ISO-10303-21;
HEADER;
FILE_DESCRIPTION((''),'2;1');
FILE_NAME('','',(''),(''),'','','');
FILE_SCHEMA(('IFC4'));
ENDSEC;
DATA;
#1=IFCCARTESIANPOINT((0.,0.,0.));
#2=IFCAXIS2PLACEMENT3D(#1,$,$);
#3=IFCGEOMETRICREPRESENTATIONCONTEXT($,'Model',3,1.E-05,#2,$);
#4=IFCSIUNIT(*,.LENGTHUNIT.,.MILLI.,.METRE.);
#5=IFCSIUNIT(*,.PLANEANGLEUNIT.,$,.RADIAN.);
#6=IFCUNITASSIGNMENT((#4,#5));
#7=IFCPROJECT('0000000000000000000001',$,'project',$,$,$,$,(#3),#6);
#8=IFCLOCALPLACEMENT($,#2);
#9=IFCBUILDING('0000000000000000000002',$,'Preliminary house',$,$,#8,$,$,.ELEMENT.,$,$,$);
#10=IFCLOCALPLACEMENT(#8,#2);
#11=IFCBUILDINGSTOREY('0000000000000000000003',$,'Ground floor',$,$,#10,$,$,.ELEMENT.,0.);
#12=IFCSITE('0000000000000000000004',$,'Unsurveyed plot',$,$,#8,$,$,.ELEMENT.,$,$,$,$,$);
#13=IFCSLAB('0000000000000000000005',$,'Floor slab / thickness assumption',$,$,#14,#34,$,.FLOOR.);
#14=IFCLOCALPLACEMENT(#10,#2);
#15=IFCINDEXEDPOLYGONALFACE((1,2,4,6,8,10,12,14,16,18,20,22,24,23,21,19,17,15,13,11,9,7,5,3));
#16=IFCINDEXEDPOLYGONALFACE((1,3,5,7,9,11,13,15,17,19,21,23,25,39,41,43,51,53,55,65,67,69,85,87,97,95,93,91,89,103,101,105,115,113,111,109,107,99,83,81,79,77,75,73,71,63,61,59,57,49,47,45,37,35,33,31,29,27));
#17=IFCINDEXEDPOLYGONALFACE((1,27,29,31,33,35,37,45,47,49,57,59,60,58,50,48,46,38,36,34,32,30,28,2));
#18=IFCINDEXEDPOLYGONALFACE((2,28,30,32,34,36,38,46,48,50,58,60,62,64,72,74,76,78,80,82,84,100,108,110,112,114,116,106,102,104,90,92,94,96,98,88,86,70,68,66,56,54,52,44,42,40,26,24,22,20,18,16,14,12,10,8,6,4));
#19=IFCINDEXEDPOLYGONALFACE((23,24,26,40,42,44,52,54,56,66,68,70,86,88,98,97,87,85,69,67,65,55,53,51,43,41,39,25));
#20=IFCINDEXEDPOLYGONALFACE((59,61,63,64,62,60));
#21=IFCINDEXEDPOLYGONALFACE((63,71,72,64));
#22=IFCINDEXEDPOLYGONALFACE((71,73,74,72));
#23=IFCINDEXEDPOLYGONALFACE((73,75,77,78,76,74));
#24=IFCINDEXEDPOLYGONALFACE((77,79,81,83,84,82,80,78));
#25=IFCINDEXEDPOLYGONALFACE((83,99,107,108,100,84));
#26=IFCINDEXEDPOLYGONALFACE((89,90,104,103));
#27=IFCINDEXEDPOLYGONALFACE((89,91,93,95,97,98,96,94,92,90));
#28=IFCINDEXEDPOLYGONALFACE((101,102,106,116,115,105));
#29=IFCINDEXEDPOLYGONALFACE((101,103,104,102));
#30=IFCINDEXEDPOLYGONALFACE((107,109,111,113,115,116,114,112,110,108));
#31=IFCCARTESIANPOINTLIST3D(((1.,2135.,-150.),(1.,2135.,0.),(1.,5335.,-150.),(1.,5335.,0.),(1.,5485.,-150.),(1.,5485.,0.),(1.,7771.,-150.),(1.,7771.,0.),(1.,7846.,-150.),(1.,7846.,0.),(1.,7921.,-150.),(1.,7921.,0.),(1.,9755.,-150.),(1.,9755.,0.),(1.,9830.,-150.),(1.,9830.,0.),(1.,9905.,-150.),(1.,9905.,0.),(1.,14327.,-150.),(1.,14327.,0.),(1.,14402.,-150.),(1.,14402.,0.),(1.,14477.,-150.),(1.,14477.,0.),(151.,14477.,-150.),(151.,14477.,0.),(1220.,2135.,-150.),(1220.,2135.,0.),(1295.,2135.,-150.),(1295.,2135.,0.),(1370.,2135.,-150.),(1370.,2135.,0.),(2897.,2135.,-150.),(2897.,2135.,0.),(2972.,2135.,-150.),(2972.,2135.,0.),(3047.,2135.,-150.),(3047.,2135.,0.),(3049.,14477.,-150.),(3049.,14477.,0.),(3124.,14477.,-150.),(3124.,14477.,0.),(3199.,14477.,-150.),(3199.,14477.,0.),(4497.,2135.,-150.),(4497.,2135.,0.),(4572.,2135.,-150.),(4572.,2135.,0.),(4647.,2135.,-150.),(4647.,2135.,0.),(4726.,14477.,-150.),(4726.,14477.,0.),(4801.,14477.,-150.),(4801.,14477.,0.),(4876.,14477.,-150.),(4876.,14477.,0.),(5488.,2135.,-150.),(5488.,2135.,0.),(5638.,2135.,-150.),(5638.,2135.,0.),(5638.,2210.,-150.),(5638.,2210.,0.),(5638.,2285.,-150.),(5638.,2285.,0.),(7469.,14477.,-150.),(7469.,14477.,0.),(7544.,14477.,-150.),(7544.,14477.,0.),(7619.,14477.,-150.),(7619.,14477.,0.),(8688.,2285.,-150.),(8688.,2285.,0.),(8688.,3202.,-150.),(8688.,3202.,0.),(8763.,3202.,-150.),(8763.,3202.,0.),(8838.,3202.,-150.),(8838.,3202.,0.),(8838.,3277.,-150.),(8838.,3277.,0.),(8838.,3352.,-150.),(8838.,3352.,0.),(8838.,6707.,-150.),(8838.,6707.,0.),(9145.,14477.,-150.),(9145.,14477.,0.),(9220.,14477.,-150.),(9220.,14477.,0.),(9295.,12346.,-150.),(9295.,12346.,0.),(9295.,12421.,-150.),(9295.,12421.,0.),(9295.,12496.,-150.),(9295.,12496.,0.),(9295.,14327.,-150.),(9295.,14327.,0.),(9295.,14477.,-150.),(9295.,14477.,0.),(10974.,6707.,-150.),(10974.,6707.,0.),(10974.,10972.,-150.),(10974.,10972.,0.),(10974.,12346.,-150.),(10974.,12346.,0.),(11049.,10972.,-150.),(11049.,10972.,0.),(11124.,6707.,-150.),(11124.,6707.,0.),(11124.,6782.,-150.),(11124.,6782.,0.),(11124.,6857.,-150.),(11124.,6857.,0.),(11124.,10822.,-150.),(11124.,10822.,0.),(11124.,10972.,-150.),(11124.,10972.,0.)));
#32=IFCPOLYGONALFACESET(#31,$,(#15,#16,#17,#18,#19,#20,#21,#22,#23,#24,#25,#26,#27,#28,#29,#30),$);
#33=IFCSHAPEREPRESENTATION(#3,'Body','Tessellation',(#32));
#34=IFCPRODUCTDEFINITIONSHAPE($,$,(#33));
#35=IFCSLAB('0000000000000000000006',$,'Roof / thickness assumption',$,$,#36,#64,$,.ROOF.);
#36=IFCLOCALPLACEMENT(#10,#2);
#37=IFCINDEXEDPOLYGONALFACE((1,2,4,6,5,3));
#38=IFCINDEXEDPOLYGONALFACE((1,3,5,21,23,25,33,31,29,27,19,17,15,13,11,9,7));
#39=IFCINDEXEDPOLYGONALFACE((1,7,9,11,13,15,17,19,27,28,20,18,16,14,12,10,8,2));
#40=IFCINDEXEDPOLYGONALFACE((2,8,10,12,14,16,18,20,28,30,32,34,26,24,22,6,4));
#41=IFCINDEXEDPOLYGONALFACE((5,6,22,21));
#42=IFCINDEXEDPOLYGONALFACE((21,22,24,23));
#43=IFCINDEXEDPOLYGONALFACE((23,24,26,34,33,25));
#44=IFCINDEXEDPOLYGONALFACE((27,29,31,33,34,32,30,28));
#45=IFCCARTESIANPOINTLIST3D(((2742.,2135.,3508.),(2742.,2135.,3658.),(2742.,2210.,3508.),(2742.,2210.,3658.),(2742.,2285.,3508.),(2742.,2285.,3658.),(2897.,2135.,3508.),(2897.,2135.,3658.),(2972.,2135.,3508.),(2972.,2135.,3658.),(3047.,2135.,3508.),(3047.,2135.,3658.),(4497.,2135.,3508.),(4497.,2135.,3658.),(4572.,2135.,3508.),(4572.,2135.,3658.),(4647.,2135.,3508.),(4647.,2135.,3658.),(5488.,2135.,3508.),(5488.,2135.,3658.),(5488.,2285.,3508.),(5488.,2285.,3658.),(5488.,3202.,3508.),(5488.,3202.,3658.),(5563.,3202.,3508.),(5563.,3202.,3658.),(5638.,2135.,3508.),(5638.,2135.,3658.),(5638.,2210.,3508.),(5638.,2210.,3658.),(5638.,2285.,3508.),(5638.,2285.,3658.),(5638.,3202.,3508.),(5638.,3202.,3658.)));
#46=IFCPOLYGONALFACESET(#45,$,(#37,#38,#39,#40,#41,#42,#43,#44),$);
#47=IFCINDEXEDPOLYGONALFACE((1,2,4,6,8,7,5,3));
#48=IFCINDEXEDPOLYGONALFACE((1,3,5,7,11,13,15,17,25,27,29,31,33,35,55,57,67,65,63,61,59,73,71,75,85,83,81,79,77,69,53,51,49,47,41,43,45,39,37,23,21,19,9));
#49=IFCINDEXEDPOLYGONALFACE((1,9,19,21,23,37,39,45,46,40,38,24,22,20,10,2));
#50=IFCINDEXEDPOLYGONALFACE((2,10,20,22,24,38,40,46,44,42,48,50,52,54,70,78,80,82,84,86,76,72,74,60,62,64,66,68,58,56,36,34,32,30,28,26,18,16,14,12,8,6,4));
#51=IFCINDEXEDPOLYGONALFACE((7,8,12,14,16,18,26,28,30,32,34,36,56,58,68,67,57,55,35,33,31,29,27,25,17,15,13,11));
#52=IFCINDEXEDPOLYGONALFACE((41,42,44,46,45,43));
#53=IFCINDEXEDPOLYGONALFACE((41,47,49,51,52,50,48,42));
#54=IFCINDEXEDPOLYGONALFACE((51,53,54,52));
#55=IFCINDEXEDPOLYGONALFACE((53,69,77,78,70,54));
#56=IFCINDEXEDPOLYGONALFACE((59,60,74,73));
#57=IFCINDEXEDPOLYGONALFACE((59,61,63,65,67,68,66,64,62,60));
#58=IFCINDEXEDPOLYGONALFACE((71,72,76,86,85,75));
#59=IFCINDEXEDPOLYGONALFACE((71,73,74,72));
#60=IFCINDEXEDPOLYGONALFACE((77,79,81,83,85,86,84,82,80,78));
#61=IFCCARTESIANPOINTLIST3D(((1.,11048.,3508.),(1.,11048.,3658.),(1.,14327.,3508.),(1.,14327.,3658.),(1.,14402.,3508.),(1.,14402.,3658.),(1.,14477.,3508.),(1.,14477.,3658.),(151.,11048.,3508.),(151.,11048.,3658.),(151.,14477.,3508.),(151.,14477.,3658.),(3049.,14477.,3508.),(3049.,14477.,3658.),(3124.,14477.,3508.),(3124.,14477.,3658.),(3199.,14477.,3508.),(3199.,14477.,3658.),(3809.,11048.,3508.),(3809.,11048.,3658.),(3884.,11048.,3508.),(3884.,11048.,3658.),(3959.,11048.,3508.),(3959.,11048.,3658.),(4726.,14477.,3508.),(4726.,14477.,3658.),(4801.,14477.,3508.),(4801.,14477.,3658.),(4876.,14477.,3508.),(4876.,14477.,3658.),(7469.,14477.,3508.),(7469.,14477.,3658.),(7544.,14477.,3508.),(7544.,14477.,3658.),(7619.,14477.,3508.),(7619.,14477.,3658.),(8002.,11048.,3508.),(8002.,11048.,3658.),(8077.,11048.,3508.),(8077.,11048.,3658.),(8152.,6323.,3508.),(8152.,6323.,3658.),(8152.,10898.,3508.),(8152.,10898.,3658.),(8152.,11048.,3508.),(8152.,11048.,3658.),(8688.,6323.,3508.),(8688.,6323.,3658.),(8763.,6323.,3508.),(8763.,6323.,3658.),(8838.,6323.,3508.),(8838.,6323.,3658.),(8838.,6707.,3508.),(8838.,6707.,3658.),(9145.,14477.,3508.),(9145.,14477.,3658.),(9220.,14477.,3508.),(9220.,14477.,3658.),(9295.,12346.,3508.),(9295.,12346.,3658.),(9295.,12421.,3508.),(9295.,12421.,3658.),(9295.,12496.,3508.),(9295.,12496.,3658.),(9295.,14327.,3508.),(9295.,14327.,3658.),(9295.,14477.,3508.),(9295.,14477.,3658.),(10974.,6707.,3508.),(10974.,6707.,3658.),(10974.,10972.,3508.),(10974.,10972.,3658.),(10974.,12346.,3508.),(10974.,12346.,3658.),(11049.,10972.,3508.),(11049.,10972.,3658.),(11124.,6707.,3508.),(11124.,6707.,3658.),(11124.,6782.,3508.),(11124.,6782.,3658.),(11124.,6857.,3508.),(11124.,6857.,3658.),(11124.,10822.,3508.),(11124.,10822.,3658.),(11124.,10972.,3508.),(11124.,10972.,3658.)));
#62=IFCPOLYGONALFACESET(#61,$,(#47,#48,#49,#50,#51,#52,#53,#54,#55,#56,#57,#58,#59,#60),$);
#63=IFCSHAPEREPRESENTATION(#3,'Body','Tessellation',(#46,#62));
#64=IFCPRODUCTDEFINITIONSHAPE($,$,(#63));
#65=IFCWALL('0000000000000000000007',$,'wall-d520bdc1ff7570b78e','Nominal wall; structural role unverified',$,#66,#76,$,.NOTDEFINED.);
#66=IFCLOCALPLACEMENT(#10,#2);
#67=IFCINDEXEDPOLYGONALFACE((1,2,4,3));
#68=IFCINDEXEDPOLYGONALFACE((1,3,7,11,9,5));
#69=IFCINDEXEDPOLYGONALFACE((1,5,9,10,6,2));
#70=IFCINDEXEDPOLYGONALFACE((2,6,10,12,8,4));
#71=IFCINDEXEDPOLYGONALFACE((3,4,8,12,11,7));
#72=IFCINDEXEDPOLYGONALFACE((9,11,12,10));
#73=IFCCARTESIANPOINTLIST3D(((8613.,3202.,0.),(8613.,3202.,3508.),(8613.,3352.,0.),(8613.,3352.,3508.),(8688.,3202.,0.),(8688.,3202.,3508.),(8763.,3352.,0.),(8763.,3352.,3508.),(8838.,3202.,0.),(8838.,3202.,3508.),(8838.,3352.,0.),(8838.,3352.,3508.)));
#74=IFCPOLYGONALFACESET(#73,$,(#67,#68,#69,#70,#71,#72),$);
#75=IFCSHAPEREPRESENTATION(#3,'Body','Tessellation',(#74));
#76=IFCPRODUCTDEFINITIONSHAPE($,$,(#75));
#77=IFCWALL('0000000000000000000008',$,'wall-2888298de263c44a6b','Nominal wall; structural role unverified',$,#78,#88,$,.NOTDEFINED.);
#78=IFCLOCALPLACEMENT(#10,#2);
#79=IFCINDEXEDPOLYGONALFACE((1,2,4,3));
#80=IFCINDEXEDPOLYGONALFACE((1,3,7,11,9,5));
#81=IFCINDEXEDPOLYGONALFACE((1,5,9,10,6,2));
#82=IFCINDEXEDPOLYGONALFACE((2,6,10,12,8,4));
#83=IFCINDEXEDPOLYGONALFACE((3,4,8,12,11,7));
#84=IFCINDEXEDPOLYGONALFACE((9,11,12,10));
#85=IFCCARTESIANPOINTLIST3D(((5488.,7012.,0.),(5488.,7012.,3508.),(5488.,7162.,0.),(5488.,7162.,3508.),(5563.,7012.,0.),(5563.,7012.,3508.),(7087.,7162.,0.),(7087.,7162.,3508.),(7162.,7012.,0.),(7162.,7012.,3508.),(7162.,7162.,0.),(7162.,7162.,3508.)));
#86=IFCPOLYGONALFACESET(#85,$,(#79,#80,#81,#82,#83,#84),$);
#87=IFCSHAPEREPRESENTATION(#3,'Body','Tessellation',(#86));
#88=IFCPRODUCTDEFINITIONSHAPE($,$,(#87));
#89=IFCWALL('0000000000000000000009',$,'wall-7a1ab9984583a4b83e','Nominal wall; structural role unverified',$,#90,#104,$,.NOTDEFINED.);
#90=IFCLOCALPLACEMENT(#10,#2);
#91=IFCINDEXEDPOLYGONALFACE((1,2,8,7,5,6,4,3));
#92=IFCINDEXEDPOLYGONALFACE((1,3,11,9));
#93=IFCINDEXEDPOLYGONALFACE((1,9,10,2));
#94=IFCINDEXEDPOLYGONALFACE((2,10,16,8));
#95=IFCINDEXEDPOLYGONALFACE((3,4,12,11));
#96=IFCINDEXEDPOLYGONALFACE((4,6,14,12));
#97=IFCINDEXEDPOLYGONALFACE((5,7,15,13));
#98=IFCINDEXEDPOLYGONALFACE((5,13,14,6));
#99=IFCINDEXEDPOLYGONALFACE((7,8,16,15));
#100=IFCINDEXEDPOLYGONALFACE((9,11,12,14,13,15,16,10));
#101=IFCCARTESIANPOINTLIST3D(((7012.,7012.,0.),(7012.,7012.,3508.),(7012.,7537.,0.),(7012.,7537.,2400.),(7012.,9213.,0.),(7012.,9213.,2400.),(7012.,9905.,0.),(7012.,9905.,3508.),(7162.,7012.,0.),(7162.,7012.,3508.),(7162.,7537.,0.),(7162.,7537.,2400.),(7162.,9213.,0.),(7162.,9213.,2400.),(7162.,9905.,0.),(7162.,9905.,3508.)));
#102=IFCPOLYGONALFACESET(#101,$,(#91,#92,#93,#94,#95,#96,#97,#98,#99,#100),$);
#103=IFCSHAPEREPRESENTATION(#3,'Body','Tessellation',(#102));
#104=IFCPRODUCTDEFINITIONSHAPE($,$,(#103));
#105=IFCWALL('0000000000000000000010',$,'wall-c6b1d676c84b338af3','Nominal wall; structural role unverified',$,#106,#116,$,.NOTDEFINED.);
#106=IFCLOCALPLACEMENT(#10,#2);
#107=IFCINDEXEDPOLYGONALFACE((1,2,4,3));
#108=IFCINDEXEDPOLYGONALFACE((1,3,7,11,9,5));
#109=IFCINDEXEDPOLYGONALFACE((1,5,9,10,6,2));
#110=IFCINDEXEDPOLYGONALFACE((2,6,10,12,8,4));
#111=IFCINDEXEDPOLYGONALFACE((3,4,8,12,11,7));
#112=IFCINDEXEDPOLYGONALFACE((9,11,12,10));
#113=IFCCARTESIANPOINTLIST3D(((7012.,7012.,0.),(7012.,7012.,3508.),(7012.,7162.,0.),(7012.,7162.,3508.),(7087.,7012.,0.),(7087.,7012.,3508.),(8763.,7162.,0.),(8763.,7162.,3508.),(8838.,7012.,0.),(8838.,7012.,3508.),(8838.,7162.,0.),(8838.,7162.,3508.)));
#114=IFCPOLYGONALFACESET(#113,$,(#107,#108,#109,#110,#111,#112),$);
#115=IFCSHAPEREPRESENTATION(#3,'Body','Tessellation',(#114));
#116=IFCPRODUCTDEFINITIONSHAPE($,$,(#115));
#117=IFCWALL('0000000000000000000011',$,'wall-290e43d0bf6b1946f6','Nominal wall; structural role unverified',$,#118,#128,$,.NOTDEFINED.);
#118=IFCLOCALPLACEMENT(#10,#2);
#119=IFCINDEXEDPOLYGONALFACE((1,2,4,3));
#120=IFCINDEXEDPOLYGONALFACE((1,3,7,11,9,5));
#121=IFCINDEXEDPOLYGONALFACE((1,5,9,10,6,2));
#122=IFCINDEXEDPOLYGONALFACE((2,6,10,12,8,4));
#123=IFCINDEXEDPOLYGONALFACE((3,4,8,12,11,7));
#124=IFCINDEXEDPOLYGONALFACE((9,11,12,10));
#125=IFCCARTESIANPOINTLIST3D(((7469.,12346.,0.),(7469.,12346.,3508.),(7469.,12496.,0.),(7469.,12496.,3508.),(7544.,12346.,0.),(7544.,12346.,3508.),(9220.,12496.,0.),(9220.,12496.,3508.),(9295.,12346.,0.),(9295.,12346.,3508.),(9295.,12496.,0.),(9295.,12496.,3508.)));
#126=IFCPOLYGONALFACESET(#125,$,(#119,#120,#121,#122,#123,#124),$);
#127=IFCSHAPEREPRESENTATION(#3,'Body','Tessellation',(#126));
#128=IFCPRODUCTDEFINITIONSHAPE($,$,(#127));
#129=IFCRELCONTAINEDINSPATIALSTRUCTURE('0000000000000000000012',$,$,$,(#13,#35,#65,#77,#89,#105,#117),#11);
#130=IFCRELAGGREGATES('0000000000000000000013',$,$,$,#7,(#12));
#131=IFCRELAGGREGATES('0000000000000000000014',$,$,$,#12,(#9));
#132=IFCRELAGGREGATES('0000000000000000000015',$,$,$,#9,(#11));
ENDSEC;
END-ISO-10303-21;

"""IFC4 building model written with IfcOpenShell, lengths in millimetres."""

from ifc_helpers import new_model, si_unit, frame, origin, place, context, project, spatial, polyline, outline, extrude, element, save


model = new_model("IFC4")

# Units and contexts
model_context = context("Model", 3, precision=1e-05, world=origin())
ifc_project = project(units=[si_unit("LENGTHUNIT", "METRE", prefix="MILLI"), si_unit("PLANEANGLEUNIT", "RADIAN")], contexts=[model_context])

# Site, building, storey
placement_1 = place(None, origin())
site = spatial("IfcSite", under=ifc_project, at=placement_1, Name="Unsurveyed plot", CompositionType="ELEMENT")
building = spatial("IfcBuilding", under=site, at=placement_1, Name="Preliminary house", CompositionType="ELEMENT")
placement_2 = place(placement_1, origin())
storey = spatial("IfcBuildingStorey", under=building, at=placement_2, Name="Ground floor", CompositionType="ELEMENT", Elevation=0.0)

# Slabs
element("IfcSlab", 1, at=placement_2, inside=storey, Name="Floor slab / thickness assumption", PredefinedType="FLOOR", context=model_context, shape_type="SweptSolid", body=[
    extrude(outline(polyline([(1220.0, 2135.0), (1.0, 2135.0), (1.0, 5335.0), (1.0, 5485.0), (1.0, 7771.0), (1.0, 7846.0), (1.0, 7921.0), (1.0, 9755.0), (1.0, 9830.0), (1.0, 9905.0), (1.0, 14327.0), (1.0, 14402.0), (1.0, 14477.0), (151.0, 14477.0), (3049.0, 14477.0), (3124.0, 14477.0), (3199.0, 14477.0), (4726.0, 14477.0), (4801.0, 14477.0), (4876.0, 14477.0), (7469.0, 14477.0), (7544.0, 14477.0), (7619.0, 14477.0), (9145.0, 14477.0), (9220.0, 14477.0), (9295.0, 14477.0), (9295.0, 14327.0), (9295.0, 12496.0), (9295.0, 12421.0), (9295.0, 12346.0), (10974.0, 12346.0), (10974.0, 10972.0), (11049.0, 10972.0), (11124.0, 10972.0), (11124.0, 10822.0), (11124.0, 6857.0), (11124.0, 6782.0), (11124.0, 6707.0), (10974.0, 6707.0), (8838.0, 6707.0), (8838.0, 3352.0), (8838.0, 3277.0), (8838.0, 3202.0), (8763.0, 3202.0), (8688.0, 3202.0), (8688.0, 2285.0), (5638.0, 2285.0), (5638.0, 2210.0), (5638.0, 2135.0), (5488.0, 2135.0), (4647.0, 2135.0), (4572.0, 2135.0), (4497.0, 2135.0), (3047.0, 2135.0), (2972.0, 2135.0), (2897.0, 2135.0), (1370.0, 2135.0), (1295.0, 2135.0), (1220.0, 2135.0)])), frame((0.0, 0.0, -150.0)), (0.0, 0.0, 1.0), 150.0),
])
element("IfcSlab", 2, at=placement_2, inside=storey, Name="Roof / thickness assumption", PredefinedType="ROOF", context=model_context, shape_type="SweptSolid", body=[
    extrude(outline(polyline([(5638.0, 2210.0), (5638.0, 2135.0), (5488.0, 2135.0), (4647.0, 2135.0), (4572.0, 2135.0), (4497.0, 2135.0), (3047.0, 2135.0), (2972.0, 2135.0), (2897.0, 2135.0), (2742.0, 2135.0), (2742.0, 2210.0), (2742.0, 2285.0), (5488.0, 2285.0), (5488.0, 3202.0), (5563.0, 3202.0), (5638.0, 3202.0), (5638.0, 2285.0), (5638.0, 2210.0)])), frame((0.0, 0.0, 3508.0)), (0.0, 0.0, 1.0), 150.0),
    extrude(outline(polyline([(1.0, 14402.0), (1.0, 14477.0), (151.0, 14477.0), (3049.0, 14477.0), (3124.0, 14477.0), (3199.0, 14477.0), (4726.0, 14477.0), (4801.0, 14477.0), (4876.0, 14477.0), (7469.0, 14477.0), (7544.0, 14477.0), (7619.0, 14477.0), (9145.0, 14477.0), (9220.0, 14477.0), (9295.0, 14477.0), (9295.0, 14327.0), (9295.0, 12496.0), (9295.0, 12421.0), (9295.0, 12346.0), (10974.0, 12346.0), (10974.0, 10972.0), (11049.0, 10972.0), (11124.0, 10972.0), (11124.0, 10822.0), (11124.0, 6857.0), (11124.0, 6782.0), (11124.0, 6707.0), (10974.0, 6707.0), (8838.0, 6707.0), (8838.0, 6323.0), (8763.0, 6323.0), (8688.0, 6323.0), (8152.0, 6323.0), (8152.0, 10898.0), (8152.0, 11048.0), (8077.0, 11048.0), (8002.0, 11048.0), (3959.0, 11048.0), (3884.0, 11048.0), (3809.0, 11048.0), (151.0, 11048.0), (1.0, 11048.0), (1.0, 14327.0), (1.0, 14402.0)])), frame((0.0, 0.0, 3508.0)), (0.0, 0.0, 1.0), 150.0),
])

# Walls
element("IfcWall", 3, at=placement_2, inside=storey, Name="wall-d520bdc1ff7570b78e", Description="Nominal wall; structural role unverified", PredefinedType="NOTDEFINED", context=model_context, shape_type="SweptSolid", body=[
    extrude(outline(polyline([(8763.0, 3352.0), (8838.0, 3352.0), (8838.0, 3202.0), (8688.0, 3202.0), (8613.0, 3202.0), (8613.0, 3352.0), (8763.0, 3352.0)])), origin(), (0.0, 0.0, 1.0), 3508.0),
])
element("IfcWall", 4, at=placement_2, inside=storey, Name="wall-2888298de263c44a6b", Description="Nominal wall; structural role unverified", PredefinedType="NOTDEFINED", context=model_context, shape_type="SweptSolid", body=[
    extrude(outline(polyline([(7087.0, 7162.0), (7162.0, 7162.0), (7162.0, 7012.0), (5563.0, 7012.0), (5488.0, 7012.0), (5488.0, 7162.0), (7087.0, 7162.0)])), origin(), (0.0, 0.0, 1.0), 3508.0),
])

# Wall, opening
wall_1 = element("IfcWall", 5, at=placement_2, inside=storey, Name="wall-7a1ab9984583a4b83e", Description="Nominal wall; structural role unverified", PredefinedType="NOTDEFINED", context=model_context, shape_type="SweptSolid", body=[
    extrude(outline(polyline([(7012.0, 9830.0), (7012.0, 9905.0), (7162.0, 9905.0), (7162.0, 7087.0), (7162.0, 7012.0), (7012.0, 7012.0), (7012.0, 9830.0)])), origin(), (0.0, 0.0, 1.0), 3508.0),
])
element("IfcOpeningElement", 6, at=placement_2, cuts=wall_1, PredefinedType="OPENING", context=model_context, shape_type="SweptSolid", body=[
    extrude(outline(polyline([(7537.0, 7537.0), (7537.0, 9213.0), (6637.0, 9213.0), (6637.0, 7537.0), (7537.0, 7537.0)])), origin(), (0.0, 0.0, 1.0), 2400.0),
])

# Wall
element("IfcWall", 7, at=placement_2, inside=storey, Name="wall-c6b1d676c84b338af3", Description="Nominal wall; structural role unverified", PredefinedType="NOTDEFINED", context=model_context, shape_type="SweptSolid", body=[
    extrude(outline(polyline([(8763.0, 7162.0), (8838.0, 7162.0), (8838.0, 7012.0), (7087.0, 7012.0), (7012.0, 7012.0), (7012.0, 7162.0), (8763.0, 7162.0)])), origin(), (0.0, 0.0, 1.0), 3508.0),
])

# Wall
element("IfcWall", 8, at=placement_2, inside=storey, Name="wall-290e43d0bf6b1946f6", Description="Nominal wall; structural role unverified", PredefinedType="NOTDEFINED", context=model_context, shape_type="SweptSolid", body=[
    extrude(outline(polyline([(9220.0, 12496.0), (9295.0, 12496.0), (9295.0, 12346.0), (7544.0, 12346.0), (7469.0, 12346.0), (7469.0, 12496.0), (9220.0, 12496.0)])), origin(), (0.0, 0.0, 1.0), 3508.0),
])

save(model, "model.ifc")
